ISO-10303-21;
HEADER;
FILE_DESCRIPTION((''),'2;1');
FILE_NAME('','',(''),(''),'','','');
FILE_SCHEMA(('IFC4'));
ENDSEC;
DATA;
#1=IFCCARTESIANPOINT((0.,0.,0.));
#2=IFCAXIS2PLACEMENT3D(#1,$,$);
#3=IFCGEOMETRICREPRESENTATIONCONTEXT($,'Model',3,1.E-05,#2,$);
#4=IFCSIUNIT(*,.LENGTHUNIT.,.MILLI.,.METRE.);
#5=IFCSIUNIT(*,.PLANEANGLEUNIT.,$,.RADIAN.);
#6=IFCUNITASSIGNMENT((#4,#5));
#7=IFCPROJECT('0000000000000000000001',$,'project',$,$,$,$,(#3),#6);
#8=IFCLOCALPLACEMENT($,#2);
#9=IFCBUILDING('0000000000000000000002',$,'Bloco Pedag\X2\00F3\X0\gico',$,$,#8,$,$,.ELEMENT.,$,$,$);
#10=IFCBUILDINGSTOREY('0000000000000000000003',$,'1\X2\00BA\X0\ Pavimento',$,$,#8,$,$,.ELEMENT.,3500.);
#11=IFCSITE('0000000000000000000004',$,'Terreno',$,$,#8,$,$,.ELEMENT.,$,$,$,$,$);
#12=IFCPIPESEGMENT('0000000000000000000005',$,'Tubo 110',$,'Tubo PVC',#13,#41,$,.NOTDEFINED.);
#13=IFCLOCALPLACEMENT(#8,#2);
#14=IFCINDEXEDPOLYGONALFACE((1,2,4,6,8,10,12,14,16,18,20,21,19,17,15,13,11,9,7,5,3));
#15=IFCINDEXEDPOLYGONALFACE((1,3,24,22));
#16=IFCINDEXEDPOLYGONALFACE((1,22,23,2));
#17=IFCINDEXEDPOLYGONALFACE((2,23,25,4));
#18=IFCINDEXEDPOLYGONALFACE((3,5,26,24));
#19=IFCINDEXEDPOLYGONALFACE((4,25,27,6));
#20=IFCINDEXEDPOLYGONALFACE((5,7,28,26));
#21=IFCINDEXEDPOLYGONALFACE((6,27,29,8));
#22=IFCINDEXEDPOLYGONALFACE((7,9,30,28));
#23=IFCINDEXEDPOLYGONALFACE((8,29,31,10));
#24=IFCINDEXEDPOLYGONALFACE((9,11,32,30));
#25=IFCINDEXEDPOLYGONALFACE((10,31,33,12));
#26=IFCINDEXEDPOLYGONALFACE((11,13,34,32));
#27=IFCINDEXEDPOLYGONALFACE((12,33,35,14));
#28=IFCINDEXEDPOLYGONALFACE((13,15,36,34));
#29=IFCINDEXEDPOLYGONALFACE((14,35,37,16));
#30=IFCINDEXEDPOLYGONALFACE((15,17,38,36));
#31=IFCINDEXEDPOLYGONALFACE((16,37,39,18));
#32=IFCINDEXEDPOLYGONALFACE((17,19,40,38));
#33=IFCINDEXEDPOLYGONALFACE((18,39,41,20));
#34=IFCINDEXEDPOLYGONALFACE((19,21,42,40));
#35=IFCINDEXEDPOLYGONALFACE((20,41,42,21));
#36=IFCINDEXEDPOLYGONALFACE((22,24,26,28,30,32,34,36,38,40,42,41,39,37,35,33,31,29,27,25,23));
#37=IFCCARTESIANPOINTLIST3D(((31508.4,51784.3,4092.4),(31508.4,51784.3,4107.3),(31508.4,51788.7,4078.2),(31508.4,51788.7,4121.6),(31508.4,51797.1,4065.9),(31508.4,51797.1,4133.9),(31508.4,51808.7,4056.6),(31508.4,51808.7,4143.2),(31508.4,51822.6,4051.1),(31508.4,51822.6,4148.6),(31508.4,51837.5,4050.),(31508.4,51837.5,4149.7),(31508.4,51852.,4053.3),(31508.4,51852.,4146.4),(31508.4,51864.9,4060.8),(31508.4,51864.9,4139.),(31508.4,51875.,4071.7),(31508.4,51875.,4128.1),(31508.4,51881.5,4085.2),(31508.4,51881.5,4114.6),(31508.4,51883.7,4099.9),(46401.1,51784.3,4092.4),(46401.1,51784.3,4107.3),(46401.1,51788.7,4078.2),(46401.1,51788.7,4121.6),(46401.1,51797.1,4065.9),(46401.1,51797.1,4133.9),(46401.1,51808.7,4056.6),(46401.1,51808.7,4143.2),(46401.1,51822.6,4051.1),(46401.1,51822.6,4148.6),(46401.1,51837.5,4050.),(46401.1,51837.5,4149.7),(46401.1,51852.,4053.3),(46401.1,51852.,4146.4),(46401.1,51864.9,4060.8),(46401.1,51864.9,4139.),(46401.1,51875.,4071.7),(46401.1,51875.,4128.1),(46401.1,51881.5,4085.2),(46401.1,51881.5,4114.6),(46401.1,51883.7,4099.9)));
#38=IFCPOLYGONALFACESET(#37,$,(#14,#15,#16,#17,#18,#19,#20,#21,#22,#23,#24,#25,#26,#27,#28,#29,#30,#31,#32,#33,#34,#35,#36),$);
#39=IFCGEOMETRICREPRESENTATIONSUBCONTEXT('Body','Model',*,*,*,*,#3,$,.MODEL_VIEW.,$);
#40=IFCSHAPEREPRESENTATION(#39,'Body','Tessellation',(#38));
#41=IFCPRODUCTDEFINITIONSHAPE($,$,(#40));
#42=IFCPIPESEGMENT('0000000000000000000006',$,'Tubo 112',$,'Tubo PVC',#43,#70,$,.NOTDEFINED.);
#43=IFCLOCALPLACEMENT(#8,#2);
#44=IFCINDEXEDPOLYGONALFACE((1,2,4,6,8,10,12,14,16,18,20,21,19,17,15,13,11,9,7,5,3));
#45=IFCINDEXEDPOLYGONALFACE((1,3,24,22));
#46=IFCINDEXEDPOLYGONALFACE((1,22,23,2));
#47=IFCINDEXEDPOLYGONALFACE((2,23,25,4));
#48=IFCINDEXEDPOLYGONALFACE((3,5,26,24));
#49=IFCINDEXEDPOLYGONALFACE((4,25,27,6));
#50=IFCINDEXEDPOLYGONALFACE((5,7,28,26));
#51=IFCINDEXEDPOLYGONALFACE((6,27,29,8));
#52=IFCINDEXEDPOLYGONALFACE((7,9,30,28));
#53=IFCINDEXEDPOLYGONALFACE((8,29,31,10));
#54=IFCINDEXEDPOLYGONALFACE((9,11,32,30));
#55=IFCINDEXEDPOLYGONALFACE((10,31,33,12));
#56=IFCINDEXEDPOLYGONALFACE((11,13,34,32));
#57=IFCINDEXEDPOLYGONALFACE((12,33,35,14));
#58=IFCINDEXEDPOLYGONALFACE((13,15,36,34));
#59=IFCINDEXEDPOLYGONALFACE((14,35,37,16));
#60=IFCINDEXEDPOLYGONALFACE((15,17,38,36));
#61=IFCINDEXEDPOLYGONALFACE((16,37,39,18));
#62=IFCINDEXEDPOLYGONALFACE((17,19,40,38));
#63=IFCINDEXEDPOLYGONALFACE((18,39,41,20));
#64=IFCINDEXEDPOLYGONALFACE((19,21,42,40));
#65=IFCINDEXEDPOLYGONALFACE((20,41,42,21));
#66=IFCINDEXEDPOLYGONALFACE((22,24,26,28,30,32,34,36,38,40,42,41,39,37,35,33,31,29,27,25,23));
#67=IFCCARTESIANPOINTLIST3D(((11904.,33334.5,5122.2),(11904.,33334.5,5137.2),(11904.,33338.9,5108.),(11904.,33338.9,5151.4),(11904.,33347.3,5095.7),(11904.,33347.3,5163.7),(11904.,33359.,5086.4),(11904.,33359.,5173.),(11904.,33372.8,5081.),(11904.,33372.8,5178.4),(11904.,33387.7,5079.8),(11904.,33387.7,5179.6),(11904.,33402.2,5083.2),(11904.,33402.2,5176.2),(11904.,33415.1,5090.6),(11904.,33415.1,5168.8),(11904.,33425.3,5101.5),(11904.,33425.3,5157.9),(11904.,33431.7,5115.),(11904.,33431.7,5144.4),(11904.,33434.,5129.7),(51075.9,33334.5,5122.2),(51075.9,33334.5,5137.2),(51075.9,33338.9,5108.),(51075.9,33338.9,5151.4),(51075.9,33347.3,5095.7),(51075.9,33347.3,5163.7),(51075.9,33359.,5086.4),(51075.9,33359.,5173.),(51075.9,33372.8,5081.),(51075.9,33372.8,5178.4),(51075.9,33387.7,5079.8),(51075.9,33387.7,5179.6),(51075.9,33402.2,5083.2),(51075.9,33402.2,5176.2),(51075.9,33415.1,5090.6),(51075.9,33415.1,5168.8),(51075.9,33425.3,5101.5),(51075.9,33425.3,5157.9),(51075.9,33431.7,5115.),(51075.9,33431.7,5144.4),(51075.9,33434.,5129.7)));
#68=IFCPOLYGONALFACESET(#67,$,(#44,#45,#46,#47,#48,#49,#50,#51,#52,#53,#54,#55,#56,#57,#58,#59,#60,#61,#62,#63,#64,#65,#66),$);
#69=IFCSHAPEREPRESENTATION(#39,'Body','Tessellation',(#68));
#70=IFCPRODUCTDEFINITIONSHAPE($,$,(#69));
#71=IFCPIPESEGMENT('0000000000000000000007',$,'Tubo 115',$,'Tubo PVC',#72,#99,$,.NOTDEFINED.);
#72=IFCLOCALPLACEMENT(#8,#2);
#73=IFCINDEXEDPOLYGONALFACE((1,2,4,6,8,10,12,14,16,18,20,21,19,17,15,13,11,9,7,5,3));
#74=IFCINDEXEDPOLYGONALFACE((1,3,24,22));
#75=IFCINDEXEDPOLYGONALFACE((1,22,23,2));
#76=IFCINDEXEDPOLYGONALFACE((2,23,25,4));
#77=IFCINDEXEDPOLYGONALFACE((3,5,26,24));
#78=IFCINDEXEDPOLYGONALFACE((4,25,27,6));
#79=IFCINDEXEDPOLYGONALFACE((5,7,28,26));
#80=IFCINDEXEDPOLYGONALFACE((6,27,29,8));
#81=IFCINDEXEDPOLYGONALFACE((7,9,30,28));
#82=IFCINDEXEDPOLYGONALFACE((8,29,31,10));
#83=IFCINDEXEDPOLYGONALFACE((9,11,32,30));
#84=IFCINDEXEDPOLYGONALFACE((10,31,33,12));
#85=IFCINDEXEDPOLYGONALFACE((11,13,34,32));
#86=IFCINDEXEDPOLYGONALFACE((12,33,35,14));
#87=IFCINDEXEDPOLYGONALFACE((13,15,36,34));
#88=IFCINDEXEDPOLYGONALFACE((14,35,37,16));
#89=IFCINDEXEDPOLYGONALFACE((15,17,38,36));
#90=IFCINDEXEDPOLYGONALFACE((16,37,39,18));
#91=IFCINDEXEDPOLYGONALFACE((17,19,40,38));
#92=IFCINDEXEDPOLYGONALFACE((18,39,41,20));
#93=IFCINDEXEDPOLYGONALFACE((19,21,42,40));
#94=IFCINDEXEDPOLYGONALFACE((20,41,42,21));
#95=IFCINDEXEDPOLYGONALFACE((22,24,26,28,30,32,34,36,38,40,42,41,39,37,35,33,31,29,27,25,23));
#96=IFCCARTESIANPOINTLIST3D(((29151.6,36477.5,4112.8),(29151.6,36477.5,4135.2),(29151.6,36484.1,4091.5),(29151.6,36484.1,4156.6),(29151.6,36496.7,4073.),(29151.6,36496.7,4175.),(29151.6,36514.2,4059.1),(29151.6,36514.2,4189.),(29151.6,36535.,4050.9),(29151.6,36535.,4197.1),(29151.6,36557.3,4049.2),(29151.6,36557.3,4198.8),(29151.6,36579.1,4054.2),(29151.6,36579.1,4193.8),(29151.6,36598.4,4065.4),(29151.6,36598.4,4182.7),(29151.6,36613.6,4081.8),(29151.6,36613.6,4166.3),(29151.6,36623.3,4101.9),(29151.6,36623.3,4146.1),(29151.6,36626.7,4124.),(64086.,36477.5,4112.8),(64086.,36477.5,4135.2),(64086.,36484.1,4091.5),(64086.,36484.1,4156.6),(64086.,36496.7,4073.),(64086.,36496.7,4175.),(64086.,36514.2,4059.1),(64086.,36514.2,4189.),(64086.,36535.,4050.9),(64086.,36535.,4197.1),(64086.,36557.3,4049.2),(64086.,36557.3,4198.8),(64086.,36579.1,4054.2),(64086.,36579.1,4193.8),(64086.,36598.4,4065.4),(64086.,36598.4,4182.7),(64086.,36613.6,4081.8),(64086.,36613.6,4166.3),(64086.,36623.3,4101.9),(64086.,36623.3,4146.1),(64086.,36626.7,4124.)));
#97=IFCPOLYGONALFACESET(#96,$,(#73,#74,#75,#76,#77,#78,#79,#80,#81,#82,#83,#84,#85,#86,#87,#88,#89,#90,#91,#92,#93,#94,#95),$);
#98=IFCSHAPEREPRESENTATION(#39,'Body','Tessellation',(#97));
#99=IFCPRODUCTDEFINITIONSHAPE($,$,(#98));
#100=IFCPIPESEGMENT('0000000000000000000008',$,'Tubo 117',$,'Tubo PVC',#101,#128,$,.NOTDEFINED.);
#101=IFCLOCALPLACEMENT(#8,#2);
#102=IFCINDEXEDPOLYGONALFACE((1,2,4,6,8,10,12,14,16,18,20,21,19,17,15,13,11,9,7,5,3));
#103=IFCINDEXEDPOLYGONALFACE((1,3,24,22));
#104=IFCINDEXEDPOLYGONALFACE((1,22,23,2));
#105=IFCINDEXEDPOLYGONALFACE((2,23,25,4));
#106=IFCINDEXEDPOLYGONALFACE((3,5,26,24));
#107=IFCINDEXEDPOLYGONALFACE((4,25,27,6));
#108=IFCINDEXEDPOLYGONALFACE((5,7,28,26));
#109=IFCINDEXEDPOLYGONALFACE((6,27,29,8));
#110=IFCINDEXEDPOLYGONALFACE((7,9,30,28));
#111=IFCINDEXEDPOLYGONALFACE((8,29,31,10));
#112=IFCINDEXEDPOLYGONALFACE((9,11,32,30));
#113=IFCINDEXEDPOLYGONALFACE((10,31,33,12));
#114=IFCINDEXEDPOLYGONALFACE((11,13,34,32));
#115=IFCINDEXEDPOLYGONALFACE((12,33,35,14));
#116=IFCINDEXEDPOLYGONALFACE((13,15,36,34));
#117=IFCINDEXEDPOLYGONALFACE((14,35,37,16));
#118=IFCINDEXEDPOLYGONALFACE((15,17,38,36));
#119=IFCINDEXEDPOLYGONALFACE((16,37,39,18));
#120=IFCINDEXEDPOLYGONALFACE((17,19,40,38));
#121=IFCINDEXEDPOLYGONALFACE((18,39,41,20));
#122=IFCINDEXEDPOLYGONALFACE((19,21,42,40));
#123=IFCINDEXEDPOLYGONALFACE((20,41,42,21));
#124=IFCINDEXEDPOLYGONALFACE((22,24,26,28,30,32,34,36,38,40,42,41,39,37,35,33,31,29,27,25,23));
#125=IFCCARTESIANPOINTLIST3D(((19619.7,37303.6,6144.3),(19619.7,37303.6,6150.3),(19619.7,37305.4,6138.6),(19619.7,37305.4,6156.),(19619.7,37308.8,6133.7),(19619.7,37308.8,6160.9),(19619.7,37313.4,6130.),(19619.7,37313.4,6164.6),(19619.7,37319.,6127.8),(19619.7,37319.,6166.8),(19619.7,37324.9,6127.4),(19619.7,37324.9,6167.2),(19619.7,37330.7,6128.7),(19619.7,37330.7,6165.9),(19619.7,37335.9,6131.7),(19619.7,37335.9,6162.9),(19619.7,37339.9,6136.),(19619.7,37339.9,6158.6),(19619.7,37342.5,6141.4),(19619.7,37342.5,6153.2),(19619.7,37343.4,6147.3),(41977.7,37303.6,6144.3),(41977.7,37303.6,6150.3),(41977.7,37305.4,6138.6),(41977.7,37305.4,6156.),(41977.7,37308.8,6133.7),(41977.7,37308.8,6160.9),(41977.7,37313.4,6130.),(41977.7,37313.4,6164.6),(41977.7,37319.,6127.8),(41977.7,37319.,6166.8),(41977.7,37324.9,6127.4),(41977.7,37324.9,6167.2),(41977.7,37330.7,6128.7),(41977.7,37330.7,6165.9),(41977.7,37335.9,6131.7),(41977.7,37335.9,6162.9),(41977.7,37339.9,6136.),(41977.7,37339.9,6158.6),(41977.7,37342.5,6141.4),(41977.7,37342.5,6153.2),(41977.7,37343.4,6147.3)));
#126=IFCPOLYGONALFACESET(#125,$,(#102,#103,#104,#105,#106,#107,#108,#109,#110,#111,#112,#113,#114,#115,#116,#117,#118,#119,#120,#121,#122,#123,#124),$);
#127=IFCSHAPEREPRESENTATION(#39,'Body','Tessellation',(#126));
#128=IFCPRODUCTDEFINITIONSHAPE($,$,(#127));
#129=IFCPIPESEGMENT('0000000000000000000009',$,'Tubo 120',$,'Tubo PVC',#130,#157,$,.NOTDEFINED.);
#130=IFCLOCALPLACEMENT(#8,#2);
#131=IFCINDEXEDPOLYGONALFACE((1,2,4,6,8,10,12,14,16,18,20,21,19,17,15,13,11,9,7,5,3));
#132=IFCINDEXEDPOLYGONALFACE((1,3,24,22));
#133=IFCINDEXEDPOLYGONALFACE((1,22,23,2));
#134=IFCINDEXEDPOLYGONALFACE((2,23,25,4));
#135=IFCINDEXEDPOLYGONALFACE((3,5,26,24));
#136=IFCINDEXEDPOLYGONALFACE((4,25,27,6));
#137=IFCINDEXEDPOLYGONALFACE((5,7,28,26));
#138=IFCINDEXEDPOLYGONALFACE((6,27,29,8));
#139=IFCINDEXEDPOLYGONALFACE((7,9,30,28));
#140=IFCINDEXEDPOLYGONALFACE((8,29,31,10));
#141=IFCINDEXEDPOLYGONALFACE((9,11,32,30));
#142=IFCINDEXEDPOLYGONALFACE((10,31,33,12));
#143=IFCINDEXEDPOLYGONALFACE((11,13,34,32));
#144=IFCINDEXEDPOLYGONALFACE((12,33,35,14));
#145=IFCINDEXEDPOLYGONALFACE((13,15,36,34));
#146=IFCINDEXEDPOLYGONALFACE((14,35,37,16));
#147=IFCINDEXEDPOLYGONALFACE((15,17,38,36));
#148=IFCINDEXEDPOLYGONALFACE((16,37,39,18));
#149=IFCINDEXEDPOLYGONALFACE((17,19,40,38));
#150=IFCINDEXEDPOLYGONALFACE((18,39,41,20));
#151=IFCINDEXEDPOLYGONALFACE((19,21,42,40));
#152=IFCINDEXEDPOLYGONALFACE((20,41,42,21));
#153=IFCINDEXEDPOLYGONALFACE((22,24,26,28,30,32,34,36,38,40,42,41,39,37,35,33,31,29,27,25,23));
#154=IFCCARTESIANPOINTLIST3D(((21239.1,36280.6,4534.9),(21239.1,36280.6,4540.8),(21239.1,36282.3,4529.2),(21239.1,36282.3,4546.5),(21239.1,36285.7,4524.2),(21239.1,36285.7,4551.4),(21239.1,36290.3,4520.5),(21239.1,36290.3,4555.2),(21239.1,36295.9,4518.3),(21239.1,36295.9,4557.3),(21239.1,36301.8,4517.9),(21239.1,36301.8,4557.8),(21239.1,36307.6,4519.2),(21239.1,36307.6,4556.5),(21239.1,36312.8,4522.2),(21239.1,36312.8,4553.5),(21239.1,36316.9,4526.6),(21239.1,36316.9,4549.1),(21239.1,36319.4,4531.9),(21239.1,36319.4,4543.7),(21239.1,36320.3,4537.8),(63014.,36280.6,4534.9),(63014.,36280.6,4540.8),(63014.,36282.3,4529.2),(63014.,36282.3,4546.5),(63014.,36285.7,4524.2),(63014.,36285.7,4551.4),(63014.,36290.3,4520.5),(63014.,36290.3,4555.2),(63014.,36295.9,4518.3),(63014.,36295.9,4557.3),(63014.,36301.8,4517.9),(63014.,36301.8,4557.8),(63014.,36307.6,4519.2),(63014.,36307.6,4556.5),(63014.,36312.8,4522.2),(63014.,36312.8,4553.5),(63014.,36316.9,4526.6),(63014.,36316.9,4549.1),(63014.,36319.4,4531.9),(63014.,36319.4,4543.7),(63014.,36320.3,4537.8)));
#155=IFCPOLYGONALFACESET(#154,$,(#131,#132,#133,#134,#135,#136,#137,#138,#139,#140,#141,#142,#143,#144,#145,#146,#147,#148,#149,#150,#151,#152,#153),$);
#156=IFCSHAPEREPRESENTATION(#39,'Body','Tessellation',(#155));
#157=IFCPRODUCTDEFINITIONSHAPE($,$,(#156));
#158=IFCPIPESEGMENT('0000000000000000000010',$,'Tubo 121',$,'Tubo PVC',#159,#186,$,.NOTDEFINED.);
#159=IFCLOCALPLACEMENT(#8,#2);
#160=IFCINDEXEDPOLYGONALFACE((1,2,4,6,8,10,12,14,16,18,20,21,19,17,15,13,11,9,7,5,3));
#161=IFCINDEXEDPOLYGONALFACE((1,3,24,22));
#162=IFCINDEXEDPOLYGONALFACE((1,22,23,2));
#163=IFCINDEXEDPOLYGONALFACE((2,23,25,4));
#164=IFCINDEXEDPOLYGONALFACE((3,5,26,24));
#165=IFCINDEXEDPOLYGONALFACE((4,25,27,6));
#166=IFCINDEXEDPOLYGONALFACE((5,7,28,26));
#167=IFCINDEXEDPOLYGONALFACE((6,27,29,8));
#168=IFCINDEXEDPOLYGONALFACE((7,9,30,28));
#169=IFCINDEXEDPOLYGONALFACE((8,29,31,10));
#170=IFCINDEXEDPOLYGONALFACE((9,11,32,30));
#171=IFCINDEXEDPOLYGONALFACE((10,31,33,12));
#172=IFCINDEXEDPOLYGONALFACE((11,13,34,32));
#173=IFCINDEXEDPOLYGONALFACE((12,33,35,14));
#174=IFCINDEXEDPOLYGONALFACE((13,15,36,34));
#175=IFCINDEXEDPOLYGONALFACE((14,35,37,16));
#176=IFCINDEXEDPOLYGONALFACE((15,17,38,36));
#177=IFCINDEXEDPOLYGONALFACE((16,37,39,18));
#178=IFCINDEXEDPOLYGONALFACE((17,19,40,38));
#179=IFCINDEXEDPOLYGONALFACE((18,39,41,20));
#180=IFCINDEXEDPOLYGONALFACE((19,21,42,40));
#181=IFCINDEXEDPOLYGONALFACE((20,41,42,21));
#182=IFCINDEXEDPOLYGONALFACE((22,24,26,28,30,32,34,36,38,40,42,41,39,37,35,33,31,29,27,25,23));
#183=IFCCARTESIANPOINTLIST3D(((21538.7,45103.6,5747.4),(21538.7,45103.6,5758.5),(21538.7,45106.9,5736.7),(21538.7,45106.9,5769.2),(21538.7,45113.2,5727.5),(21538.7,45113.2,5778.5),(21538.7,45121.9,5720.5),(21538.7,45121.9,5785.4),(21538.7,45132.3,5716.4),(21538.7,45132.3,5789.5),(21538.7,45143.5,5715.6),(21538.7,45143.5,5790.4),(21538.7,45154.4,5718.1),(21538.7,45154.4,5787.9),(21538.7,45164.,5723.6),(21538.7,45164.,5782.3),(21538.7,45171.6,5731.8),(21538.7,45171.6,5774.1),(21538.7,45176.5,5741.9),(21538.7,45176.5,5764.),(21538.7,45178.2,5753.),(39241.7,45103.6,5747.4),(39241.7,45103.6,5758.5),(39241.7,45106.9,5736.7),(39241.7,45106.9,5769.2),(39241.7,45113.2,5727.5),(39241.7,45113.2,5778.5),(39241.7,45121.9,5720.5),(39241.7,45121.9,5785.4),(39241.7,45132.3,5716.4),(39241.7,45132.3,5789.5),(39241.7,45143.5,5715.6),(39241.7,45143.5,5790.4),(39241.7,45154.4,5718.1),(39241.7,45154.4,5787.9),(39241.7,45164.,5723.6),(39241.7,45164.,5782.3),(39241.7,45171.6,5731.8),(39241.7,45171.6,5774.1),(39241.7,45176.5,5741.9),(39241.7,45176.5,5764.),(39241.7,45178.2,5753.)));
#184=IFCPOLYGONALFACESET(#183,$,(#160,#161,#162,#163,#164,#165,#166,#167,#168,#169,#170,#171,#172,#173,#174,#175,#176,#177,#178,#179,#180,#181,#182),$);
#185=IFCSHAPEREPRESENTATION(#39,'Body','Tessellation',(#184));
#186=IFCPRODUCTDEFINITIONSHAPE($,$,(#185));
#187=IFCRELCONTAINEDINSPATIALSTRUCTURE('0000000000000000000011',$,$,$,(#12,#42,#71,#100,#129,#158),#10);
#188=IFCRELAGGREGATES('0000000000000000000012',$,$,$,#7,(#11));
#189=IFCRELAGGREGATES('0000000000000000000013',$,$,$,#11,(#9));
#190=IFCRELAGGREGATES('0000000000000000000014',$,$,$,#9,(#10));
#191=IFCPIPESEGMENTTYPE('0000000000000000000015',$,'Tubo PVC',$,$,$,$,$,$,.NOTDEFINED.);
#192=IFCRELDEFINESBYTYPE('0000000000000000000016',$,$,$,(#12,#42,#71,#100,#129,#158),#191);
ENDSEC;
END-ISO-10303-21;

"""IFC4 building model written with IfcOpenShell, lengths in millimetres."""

from ifc_helpers import new_model, si_unit, frame, origin, origin_2d, place, context, subcontext, project, spatial, circle, extrude, type_object, element, save


model = new_model("IFC4")

# Units and contexts
model_context = context("Model", 3, precision=1e-05, world=origin())
body_context = subcontext(model_context, "Body", "Model", "MODEL_VIEW")
ifc_project = project(units=[si_unit("LENGTHUNIT", "METRE", prefix="MILLI"), si_unit("PLANEANGLEUNIT", "RADIAN")], contexts=[model_context])

# Site, building, storey
placement = place(None, origin())
site = spatial("IfcSite", under=ifc_project, at=placement, Name="Terreno", CompositionType="ELEMENT")
building = spatial("IfcBuilding", under=site, at=placement, Name="Bloco Pedagógico", CompositionType="ELEMENT")
storey = spatial("IfcBuildingStorey", under=building, at=placement, Name="1º Pavimento", CompositionType="ELEMENT", Elevation=3500.0)

# Pipe segments
pipe_segment_type = type_object("IfcPipeSegmentType", Name="Tubo PVC", PredefinedType="NOTDEFINED")
pipe_segment_1_placement = place(None, frame((31508.4, 51833.7, 4099.9), z_axis=(1.0, 0.0, 0.0), x_axis=(0.0, 1.0, 0.0)))
element("IfcPipeSegment", 1, at=pipe_segment_1_placement, inside=storey, type_object=pipe_segment_type, Name="Tubo 110", ObjectType="Tubo PVC", PredefinedType="NOTDEFINED", context=body_context, shape_type="SweptSolid", body=[
    extrude(circle(Radius=50.0, at=origin_2d()), None, (0.0, 0.0, 1.0), 14892.6),
])
pipe_segment_2_placement = place(None, frame((11904.0, 33384.0, 5129.7), z_axis=(1.0, 0.0, 0.0), x_axis=(0.0, 1.0, 0.0)))
element("IfcPipeSegment", 2, at=pipe_segment_2_placement, inside=storey, type_object=pipe_segment_type, Name="Tubo 112", ObjectType="Tubo PVC", PredefinedType="NOTDEFINED", context=body_context, shape_type="SweptSolid", body=[
    extrude(circle(Radius=50.0, at=origin_2d()), None, (0.0, 0.0, 1.0), 39171.9),
])
pipe_segment_3_placement = place(None, frame((29151.6, 36551.7, 4124.0), z_axis=(1.0, 0.0, 0.0), x_axis=(0.0, 1.0, 0.0)))
element("IfcPipeSegment", 3, at=pipe_segment_3_placement, inside=storey, type_object=pipe_segment_type, Name="Tubo 115", ObjectType="Tubo PVC", PredefinedType="NOTDEFINED", context=body_context, shape_type="SweptSolid", body=[
    extrude(circle(Radius=75.0, at=origin_2d()), None, (0.0, 0.0, 1.0), 34934.5),
])
pipe_segment_4_placement = place(None, frame((19619.7, 37323.4, 6147.3), z_axis=(1.0, 0.0, 0.0), x_axis=(0.0, 1.0, 0.0)))
element("IfcPipeSegment", 4, at=pipe_segment_4_placement, inside=storey, type_object=pipe_segment_type, Name="Tubo 117", ObjectType="Tubo PVC", PredefinedType="NOTDEFINED", context=body_context, shape_type="SweptSolid", body=[
    extrude(circle(Radius=20.0, at=origin_2d()), None, (0.0, 0.0, 1.0), 22357.9),
])
pipe_segment_5_placement = place(None, frame((21239.1, 36300.3, 4537.8), z_axis=(1.0, 0.0, 0.0), x_axis=(0.0, 1.0, 0.0)))
element("IfcPipeSegment", 5, at=pipe_segment_5_placement, inside=storey, type_object=pipe_segment_type, Name="Tubo 120", ObjectType="Tubo PVC", PredefinedType="NOTDEFINED", context=body_context, shape_type="SweptSolid", body=[
    extrude(circle(Radius=20.0, at=origin_2d()), None, (0.0, 0.0, 1.0), 41774.9),
])
pipe_segment_6_placement = place(None, frame((21538.7, 45140.7, 5753.0), z_axis=(1.0, 0.0, 0.0), x_axis=(0.0, 1.0, 0.0)))
element("IfcPipeSegment", 6, at=pipe_segment_6_placement, inside=storey, type_object=pipe_segment_type, Name="Tubo 121", ObjectType="Tubo PVC", PredefinedType="NOTDEFINED", context=body_context, shape_type="SweptSolid", body=[
    extrude(circle(Radius=37.5, at=origin_2d()), None, (0.0, 0.0, 1.0), 17703.1),
])

save(model, "model.ifc")
